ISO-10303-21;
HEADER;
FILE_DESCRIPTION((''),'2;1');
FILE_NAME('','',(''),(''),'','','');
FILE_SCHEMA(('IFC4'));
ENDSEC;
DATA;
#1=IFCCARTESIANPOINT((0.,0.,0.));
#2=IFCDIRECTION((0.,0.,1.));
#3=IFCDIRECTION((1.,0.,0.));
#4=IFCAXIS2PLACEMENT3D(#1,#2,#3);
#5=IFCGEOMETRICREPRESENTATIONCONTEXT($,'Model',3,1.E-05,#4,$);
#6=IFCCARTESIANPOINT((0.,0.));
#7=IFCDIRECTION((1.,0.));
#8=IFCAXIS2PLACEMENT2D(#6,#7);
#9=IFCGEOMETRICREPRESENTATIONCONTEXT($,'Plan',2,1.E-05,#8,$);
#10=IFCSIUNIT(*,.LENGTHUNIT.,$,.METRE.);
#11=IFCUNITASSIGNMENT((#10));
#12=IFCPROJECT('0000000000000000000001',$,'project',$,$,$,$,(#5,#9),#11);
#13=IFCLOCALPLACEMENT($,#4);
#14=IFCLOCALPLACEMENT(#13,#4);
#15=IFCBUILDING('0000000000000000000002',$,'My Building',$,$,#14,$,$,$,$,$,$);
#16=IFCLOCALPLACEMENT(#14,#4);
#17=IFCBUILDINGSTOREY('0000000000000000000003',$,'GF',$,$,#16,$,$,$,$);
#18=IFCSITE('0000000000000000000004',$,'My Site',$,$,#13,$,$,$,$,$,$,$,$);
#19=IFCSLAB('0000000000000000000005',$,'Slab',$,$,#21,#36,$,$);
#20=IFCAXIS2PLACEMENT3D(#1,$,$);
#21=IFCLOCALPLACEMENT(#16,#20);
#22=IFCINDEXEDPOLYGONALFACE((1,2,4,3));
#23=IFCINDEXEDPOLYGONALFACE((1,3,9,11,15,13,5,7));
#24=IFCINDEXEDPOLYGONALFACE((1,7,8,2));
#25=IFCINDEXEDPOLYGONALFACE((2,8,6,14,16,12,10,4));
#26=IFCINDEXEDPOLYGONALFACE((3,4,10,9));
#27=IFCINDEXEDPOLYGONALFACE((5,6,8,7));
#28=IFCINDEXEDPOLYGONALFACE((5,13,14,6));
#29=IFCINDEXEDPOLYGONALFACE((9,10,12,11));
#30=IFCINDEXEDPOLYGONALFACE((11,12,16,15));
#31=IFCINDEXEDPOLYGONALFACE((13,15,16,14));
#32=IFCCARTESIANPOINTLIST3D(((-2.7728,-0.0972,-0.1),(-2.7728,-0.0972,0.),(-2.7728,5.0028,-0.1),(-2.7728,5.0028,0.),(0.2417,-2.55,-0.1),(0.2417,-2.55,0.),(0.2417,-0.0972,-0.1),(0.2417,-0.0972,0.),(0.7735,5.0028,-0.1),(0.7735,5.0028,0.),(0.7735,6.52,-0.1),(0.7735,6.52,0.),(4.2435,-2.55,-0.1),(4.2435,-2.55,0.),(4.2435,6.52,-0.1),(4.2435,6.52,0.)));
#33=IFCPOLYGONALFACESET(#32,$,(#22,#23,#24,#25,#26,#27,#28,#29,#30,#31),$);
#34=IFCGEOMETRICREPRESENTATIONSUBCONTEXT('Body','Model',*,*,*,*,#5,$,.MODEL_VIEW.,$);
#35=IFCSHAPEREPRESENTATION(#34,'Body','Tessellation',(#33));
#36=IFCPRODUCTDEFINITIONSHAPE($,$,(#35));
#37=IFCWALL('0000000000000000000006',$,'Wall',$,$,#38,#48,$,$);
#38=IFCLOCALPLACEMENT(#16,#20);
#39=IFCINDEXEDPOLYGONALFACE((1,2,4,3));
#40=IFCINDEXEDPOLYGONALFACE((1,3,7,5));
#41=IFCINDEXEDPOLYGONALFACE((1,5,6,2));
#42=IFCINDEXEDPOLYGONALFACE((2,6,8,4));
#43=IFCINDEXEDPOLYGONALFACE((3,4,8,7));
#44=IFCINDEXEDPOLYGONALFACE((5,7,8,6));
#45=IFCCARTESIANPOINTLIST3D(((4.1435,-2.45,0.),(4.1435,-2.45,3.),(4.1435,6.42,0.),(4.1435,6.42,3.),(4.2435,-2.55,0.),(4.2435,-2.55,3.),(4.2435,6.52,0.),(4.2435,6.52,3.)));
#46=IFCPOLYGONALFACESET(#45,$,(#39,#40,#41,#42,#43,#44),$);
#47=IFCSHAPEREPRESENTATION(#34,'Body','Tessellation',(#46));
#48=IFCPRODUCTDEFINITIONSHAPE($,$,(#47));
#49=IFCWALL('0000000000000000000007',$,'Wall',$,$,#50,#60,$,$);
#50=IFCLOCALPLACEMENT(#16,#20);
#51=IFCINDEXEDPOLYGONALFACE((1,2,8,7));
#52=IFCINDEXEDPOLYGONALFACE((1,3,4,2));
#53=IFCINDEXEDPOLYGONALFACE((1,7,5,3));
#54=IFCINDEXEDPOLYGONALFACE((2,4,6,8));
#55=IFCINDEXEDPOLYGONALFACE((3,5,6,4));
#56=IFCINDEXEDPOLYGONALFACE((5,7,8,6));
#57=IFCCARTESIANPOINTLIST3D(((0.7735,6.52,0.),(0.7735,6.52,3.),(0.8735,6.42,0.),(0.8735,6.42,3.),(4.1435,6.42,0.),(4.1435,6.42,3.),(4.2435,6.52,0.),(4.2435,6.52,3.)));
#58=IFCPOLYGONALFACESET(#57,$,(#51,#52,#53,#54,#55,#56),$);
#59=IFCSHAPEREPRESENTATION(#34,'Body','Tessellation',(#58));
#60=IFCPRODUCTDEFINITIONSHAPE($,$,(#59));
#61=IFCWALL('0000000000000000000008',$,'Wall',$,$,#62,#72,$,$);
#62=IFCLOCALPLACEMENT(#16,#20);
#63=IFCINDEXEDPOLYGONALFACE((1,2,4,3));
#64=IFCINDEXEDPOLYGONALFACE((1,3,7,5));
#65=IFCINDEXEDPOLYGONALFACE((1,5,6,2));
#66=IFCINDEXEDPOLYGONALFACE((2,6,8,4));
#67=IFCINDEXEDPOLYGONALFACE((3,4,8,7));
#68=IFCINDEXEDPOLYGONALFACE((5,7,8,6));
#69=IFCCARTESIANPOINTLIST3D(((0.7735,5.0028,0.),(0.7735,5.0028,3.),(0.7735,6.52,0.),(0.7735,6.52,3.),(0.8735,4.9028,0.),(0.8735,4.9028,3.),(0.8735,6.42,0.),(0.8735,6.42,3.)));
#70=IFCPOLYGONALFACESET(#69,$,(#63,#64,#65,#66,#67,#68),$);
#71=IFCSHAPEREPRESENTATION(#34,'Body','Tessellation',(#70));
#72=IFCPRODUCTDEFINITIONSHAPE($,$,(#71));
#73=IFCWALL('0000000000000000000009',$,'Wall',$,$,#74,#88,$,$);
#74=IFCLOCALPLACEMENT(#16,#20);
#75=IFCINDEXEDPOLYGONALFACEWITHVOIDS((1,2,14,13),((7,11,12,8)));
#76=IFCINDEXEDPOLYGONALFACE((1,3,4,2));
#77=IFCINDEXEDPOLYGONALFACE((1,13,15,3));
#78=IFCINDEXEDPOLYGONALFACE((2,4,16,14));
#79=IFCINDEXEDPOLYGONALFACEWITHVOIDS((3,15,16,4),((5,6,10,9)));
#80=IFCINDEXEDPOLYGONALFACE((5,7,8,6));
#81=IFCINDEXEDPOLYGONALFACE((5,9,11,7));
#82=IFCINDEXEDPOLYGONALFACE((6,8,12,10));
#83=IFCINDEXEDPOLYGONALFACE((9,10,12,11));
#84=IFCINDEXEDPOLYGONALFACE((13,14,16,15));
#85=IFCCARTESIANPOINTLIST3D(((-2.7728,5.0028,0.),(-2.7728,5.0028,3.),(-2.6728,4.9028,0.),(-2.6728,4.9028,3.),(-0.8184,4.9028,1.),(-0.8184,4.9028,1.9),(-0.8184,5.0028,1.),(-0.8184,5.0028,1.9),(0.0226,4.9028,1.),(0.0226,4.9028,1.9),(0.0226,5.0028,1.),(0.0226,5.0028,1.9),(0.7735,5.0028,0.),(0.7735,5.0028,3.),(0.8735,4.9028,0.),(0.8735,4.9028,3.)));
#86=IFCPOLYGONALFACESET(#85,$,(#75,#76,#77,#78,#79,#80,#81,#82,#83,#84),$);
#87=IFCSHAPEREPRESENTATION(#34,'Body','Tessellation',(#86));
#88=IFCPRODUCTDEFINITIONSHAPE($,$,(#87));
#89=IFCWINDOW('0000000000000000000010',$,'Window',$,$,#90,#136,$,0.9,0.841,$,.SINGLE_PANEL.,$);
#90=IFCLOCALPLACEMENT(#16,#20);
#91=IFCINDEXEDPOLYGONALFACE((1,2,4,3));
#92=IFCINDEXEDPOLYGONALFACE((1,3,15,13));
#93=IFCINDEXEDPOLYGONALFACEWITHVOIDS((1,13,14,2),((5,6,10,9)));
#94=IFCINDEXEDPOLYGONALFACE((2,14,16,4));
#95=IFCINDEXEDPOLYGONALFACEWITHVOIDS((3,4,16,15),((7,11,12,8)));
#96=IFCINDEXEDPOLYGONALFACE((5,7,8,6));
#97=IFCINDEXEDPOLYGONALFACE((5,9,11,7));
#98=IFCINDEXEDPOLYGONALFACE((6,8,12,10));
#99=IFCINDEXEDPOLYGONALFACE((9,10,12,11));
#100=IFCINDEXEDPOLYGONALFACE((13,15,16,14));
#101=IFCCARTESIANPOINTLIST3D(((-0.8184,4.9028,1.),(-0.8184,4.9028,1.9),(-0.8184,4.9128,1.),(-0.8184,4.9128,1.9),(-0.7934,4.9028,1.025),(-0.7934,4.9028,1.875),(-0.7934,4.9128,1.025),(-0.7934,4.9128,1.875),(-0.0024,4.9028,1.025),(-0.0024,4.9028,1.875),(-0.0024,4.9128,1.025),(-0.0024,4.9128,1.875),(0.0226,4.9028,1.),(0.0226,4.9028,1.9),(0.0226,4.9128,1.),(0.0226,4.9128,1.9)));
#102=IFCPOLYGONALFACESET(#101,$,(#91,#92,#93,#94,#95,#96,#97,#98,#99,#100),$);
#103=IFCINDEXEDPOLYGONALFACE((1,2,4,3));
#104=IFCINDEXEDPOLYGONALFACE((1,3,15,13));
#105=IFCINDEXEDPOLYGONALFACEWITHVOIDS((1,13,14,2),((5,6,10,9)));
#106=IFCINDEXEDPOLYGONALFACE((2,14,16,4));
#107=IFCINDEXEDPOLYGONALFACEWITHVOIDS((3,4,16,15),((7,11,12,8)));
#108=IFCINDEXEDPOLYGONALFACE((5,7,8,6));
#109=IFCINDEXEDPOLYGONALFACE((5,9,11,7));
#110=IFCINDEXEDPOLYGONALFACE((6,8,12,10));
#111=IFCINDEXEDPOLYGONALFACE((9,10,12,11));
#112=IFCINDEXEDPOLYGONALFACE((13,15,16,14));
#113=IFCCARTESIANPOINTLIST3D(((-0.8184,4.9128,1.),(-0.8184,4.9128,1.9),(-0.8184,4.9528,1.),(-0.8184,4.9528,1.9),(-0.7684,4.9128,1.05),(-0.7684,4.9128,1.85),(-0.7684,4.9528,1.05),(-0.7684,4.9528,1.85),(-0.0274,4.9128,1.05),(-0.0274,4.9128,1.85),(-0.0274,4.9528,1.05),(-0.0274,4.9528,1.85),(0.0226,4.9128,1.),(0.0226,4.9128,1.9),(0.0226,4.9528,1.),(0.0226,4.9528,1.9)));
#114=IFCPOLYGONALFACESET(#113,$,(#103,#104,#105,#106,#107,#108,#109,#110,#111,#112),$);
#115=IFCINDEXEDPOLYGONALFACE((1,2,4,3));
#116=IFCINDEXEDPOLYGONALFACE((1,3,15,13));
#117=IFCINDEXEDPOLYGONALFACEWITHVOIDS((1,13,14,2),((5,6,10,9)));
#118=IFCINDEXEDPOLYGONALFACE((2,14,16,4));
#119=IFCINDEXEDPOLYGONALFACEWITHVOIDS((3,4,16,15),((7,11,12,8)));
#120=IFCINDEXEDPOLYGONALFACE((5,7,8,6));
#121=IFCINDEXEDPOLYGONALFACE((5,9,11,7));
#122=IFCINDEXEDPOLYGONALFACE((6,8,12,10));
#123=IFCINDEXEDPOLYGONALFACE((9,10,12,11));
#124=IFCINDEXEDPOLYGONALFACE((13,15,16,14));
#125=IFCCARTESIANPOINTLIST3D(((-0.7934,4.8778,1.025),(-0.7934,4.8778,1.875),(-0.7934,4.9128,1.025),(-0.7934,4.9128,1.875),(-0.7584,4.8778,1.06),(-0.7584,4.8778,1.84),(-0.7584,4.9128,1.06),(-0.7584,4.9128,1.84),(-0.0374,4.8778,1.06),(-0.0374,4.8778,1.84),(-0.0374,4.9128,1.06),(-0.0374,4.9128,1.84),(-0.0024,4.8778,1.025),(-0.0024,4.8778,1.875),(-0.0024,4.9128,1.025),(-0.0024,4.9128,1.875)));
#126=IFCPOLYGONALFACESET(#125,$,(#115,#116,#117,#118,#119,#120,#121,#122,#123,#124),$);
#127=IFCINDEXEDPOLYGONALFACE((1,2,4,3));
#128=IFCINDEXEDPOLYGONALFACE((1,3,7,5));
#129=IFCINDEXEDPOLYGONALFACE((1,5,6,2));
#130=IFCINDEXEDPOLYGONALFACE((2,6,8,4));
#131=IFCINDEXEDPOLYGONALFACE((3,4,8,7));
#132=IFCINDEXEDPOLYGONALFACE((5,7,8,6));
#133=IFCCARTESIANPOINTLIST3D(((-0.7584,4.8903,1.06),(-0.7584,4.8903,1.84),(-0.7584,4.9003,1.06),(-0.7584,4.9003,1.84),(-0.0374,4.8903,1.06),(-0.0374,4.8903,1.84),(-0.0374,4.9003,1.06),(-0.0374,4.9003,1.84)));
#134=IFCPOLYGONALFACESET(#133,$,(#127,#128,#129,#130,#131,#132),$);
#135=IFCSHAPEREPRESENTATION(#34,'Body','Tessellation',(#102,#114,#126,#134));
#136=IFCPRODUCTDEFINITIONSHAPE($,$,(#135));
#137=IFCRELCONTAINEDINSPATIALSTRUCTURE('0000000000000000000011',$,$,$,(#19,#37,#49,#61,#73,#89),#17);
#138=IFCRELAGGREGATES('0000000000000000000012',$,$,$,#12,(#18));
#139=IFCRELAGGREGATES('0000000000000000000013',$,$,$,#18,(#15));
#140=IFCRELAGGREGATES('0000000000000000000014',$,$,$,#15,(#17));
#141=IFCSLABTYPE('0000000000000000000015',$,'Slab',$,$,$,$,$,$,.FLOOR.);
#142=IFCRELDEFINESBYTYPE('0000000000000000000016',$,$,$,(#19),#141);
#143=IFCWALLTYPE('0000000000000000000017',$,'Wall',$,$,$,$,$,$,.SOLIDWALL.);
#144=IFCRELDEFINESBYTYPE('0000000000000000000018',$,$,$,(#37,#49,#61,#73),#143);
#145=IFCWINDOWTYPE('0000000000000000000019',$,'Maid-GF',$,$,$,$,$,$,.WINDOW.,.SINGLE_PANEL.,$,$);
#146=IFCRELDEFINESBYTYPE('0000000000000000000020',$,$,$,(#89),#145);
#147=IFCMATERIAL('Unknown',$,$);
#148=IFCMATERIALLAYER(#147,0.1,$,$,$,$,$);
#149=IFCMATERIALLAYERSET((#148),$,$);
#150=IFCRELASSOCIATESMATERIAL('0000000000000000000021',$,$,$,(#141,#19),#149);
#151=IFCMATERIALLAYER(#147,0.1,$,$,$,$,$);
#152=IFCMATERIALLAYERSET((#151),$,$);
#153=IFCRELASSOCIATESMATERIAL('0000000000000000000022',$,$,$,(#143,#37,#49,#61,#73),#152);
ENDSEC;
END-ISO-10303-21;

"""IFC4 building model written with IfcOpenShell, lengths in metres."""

from ifc_helpers import new_model, entity, si_unit, frame, origin_with_axes, origin_2d_with_axis, place, context, subcontext, project, spatial, line, indexed_curve, outline, extrude, shape, source, transform, mapped, material, layer, layer_set, layer_usage, type_object, type_shapes, element, fill, save


model = new_model("IFC4")

# Units and contexts
model_context = context("Model", 3, precision=1e-05, world=origin_with_axes())
plan_context = context("Plan", 2, precision=1e-05, world=origin_2d_with_axis())
body_context_1 = subcontext(model_context, "Body", "Model", "MODEL_VIEW")
body_context_2 = subcontext(plan_context, "Body", "Plan", "PLAN_VIEW")
ifc_project = project(units=[si_unit("LENGTHUNIT", "METRE")], contexts=[model_context, plan_context])

# Site, building, storey
site_placement = place(None, origin_with_axes())
site = spatial("IfcSite", under=ifc_project, at=site_placement, Name="My Site")
building_placement = place(site_placement, origin_with_axes())
building = spatial("IfcBuilding", under=site, at=building_placement, Name="My Building")
storey_placement = place(building_placement, origin_with_axes())
storey = spatial("IfcBuildingStorey", under=building, at=storey_placement, Name="GF")

# Slab
ifc_material = material(Name="Unknown")
ifc_layer_1 = layer(ifc_material, 0.1)
ifc_layer_set_1 = layer_set([ifc_layer_1])
ifc_layer_usage_1 = layer_usage(ifc_layer_set_1, "AXIS3", "POSITIVE", -0.1)
slab_type = type_object("IfcSlabType", Name="Slab", PredefinedType="FLOOR", material=ifc_layer_set_1)
slab_placement = place(storey_placement, frame((4.2435, 6.52, 0.0), z_axis=(0.0, 0.0, 1.0), x_axis=(1.0, 0.0, 0.0)))
element("IfcSlab", 1, at=slab_placement, inside=storey, type_object=slab_type, material=ifc_layer_usage_1, Name="Slab", context=body_context_1, shape_type="SweptSolid", body=[
    extrude(outline(indexed_curve([(0.0, 0.0), (-3.47, 0.0), (-3.47, -1.5172), (-7.0163, -1.5172), (-7.0163, -6.6172), (-4.0018, -6.6172), (-4.0018, -9.07), (0.0, -9.07), (0.0, 0.0)])), frame((0.0, 0.0, -0.1), z_axis=(0.0, 0.0, 1.0), x_axis=(1.0, 0.0, 0.0)), (0.0, 0.0, 1.0), 0.1),
])

# Shared definitions
ifc_layer_2 = layer(ifc_material, 0.1)
ifc_layer_set_2 = layer_set([ifc_layer_2])
wall_type = type_object("IfcWallType", Name="Wall", PredefinedType="SOLIDWALL", material=ifc_layer_set_2)

# Walls
ifc_layer_usage_2 = layer_usage(ifc_layer_set_2, "AXIS2", "POSITIVE", 0.0)
wall_1_placement = place(storey_placement, frame((4.2435, -2.45, 0.0), z_axis=(0.0, 0.0, 1.0), x_axis=(0.0, 1.0, 0.0)))
element("IfcWall", 2, at=wall_1_placement, inside=storey, type_object=wall_type, material=ifc_layer_usage_2, Name="Wall", context=body_context_1, shape_type="SweptSolid", body=[
    extrude(outline(indexed_curve([(-0.1, 0.0), (0.0, 0.1), (8.87, 0.1), (8.97, 0.0)], segments=[line(1, 2, 3, 4, 1)])), origin_with_axes(), (0.0, 0.0, 1.0), 3.0),
])
ifc_layer_usage_3 = layer_usage(ifc_layer_set_2, "AXIS2", "POSITIVE", 0.0)
wall_2_placement = place(storey_placement, frame((4.2435, 6.52, 0.0), z_axis=(0.0, 0.0, 1.0), x_axis=(-1.0, 0.0, 0.0)))
element("IfcWall", 3, at=wall_2_placement, inside=storey, type_object=wall_type, material=ifc_layer_usage_3, Name="Wall", context=body_context_1, shape_type="SweptSolid", body=[
    extrude(outline(indexed_curve([(0.0, 0.0), (0.1, 0.1), (3.37, 0.1), (3.47, 0.0)], segments=[line(1, 2, 3, 4, 1)])), origin_with_axes(), (0.0, 0.0, 1.0), 3.0),
])
ifc_layer_usage_4 = layer_usage(ifc_layer_set_2, "AXIS2", "POSITIVE", 0.0)
wall_3_placement = place(storey_placement, frame((0.7735, 6.52, 0.0), z_axis=(0.0, 0.0, 1.0), x_axis=(0.0, -1.0, 0.0)))
element("IfcWall", 4, at=wall_3_placement, inside=storey, type_object=wall_type, material=ifc_layer_usage_4, Name="Wall", context=body_context_1, shape_type="SweptSolid", body=[
    extrude(outline(indexed_curve([(0.0, 0.0), (0.1, 0.1), (1.6172, 0.1), (1.5172, 0.0)], segments=[line(1, 2, 3, 4, 1)])), origin_with_axes(), (0.0, 0.0, 1.0), 3.0),
])

# Wall, opening, window
ifc_layer_usage_5 = layer_usage(ifc_layer_set_2, "AXIS2", "POSITIVE", 0.0)
wall_4_placement = place(storey_placement, frame((0.7735, 5.0028, 0.0), z_axis=(0.0, 0.0, 1.0), x_axis=(-1.0, 0.0, 0.0)))
wall_4 = element("IfcWall", 5, at=wall_4_placement, inside=storey, type_object=wall_type, material=ifc_layer_usage_5, Name="Wall", context=body_context_1, shape_type="SweptSolid", body=[
    extrude(outline(indexed_curve([(0.0, 0.0), (-0.1, 0.1), (3.4463, 0.1), (3.5463, 0.0)], segments=[line(1, 2, 3, 4, 1)])), origin_with_axes(), (0.0, 0.0, 1.0), 3.0),
])
shared_shape_1 = source(origin_with_axes(), body_context_1, "Body", "SweptSolid", [
    extrude(outline(indexed_curve([(0.0, 0.0), (0.841, 0.0), (0.841, 0.9), (0.0, 0.9)], segments=[line(1, 2, 3, 4, 1)])), frame((0.0, -0.6, 0.0), z_axis=(0.0, -1.0, 0.0), x_axis=(1.0, 0.0, 0.0)), (0.0, 0.0, -1.0), 1.2),
])
opening_1_placement = place(wall_4_placement, frame((0.7509, 0.0, 1.0), z_axis=(0.0, 0.0, 1.0), x_axis=(1.0, 0.0, 0.0)))
opening_1 = element("IfcOpeningElement", 6, at=opening_1_placement, cuts=wall_4, PredefinedType="OPENING", context=body_context_1, shape_type="MappedRepresentation", body=[
    mapped(shared_shape_1, transform((0.0, 0.0, 0.0), x_axis=(1.0, 0.0, 0.0), y_axis=(0.0, 1.0, 0.0), z_axis=(0.0, 0.0, 1.0), scale=1.0)),
])
window_type_1 = type_object("IfcWindowType", Name="Maid-GF", PartitioningType="SINGLE_PANEL", PredefinedType="WINDOW")
shared_shape_2 = source(origin_with_axes(), body_context_1, "Body", "SweptSolid", [
    extrude(outline(indexed_curve([(0.0, 0.0), (0.841, 0.0), (0.841, 0.9), (0.0, 0.9)], segments=[line(1, 2, 3, 4, 1)]), holes=[indexed_curve([(0.025, 0.025), (0.816, 0.025), (0.816, 0.875), (0.025, 0.875)], segments=[line(1, 2, 3, 4, 1)])]), frame((0.0, 0.09, 0.0), z_axis=(0.0, -1.0, 0.0), x_axis=(1.0, 0.0, 0.0)), (0.0, 0.0, -1.0), 0.01),
    extrude(outline(indexed_curve([(0.0, 0.0), (0.841, 0.0), (0.841, 0.9), (0.0, 0.9)], segments=[line(1, 2, 3, 4, 1)]), holes=[indexed_curve([(0.05, 0.05), (0.791, 0.05), (0.791, 0.85), (0.05, 0.85)], segments=[line(1, 2, 3, 4, 1)])]), frame((0.0, 0.05, 0.0), z_axis=(0.0, -1.0, 0.0), x_axis=(1.0, 0.0, 0.0)), (0.0, 0.0, -1.0), 0.04),
    extrude(outline(indexed_curve([(0.0, 0.0), (0.791, 0.0), (0.791, 0.85), (0.0, 0.85)], segments=[line(1, 2, 3, 4, 1)]), holes=[indexed_curve([(0.035, 0.035), (0.756, 0.035), (0.756, 0.815), (0.035, 0.815)], segments=[line(1, 2, 3, 4, 1)])]), frame((0.025, 0.09, 0.025), z_axis=(0.0, -1.0, 0.0), x_axis=(1.0, 0.0, 0.0)), (0.0, 0.0, -1.0), 0.035),
    extrude(outline(indexed_curve([(0.035, 0.035), (0.756, 0.035), (0.756, 0.815), (0.035, 0.815)], segments=[line(1, 2, 3, 4, 1)])), frame((0.025, 0.1025, 0.025), z_axis=(0.0, -1.0, 0.0), x_axis=(1.0, 0.0, 0.0)), (0.0, 0.0, -1.0), 0.01),
])
shared_shape_3 = source(origin_with_axes(), body_context_2, "Body", "Curve2D", [
    entity("IfcIndexedPolyCurve", entity("IfcCartesianPointList2D", [[0.05, 0.05], [0.791, 0.05]])),
    entity("IfcIndexedPolyCurve", entity("IfcCartesianPointList2D", [[0.0, 0.1], [0.025, 0.1], [0.025, 0.09], [0.05, 0.09], [0.05, 0.05], [0.0, 0.05]]), [entity("IfcLineIndex", [1, 2, 3, 4, 5, 6, 1])]),
    entity("IfcIndexedPolyCurve", entity("IfcCartesianPointList2D", [[0.841, 0.1], [0.816, 0.1], [0.816, 0.09], [0.791, 0.09], [0.791, 0.05], [0.841, 0.05]]), [entity("IfcLineIndex", [1, 2, 3, 4, 5, 6, 1])]),
    entity("IfcIndexedPolyCurve", entity("IfcCartesianPointList2D", [[0.025, 0.09], [0.06, 0.09], [0.06, 0.125], [0.025, 0.125]]), [entity("IfcLineIndex", [1, 2, 3, 4, 1])]),
    entity("IfcIndexedPolyCurve", entity("IfcCartesianPointList2D", [[0.816, 0.09], [0.781, 0.09], [0.781, 0.125], [0.816, 0.125]]), [entity("IfcLineIndex", [1, 2, 3, 4, 1])]),
    entity("IfcIndexedPolyCurve", entity("IfcCartesianPointList2D", [[0.06, 0.09], [0.781, 0.09]])),
    entity("IfcIndexedPolyCurve", entity("IfcCartesianPointList2D", [[0.06, 0.125], [0.781, 0.125]])),
    entity("IfcIndexedPolyCurve", entity("IfcCartesianPointList2D", [[0.06, 0.1075], [0.781, 0.1075]])),
])
type_shapes(window_type_1, [shared_shape_2, shared_shape_3])
window_1_placement = place(opening_1_placement, frame((0.0, 0.0, 0.0), z_axis=(0.0, 0.0, 1.0), x_axis=(1.0, 0.0, 0.0)))
window_1 = element("IfcWindow", 7, at=window_1_placement, inside=storey, type_object=window_type_1, Name="Window", OverallHeight=0.9, OverallWidth=0.841, PartitioningType="SINGLE_PANEL", shapes=[
    shape(body_context_1, "Body", "MappedRepresentation", [mapped(shared_shape_2, transform((0.0, 0.0, 0.0), x_axis=(1.0, 0.0, 0.0), y_axis=(0.0, 1.0, 0.0), z_axis=(0.0, 0.0, 1.0), scale=1.0))]),
    shape(body_context_2, "Body", "MappedRepresentation", [mapped(shared_shape_3, transform((0.0, 0.0, 0.0), x_axis=(1.0, 0.0, 0.0), y_axis=(0.0, 1.0, 0.0), z_axis=(0.0, 0.0, 1.0), scale=1.0))]),
])
fill(opening_1, window_1)

save(model, "model.ifc")
